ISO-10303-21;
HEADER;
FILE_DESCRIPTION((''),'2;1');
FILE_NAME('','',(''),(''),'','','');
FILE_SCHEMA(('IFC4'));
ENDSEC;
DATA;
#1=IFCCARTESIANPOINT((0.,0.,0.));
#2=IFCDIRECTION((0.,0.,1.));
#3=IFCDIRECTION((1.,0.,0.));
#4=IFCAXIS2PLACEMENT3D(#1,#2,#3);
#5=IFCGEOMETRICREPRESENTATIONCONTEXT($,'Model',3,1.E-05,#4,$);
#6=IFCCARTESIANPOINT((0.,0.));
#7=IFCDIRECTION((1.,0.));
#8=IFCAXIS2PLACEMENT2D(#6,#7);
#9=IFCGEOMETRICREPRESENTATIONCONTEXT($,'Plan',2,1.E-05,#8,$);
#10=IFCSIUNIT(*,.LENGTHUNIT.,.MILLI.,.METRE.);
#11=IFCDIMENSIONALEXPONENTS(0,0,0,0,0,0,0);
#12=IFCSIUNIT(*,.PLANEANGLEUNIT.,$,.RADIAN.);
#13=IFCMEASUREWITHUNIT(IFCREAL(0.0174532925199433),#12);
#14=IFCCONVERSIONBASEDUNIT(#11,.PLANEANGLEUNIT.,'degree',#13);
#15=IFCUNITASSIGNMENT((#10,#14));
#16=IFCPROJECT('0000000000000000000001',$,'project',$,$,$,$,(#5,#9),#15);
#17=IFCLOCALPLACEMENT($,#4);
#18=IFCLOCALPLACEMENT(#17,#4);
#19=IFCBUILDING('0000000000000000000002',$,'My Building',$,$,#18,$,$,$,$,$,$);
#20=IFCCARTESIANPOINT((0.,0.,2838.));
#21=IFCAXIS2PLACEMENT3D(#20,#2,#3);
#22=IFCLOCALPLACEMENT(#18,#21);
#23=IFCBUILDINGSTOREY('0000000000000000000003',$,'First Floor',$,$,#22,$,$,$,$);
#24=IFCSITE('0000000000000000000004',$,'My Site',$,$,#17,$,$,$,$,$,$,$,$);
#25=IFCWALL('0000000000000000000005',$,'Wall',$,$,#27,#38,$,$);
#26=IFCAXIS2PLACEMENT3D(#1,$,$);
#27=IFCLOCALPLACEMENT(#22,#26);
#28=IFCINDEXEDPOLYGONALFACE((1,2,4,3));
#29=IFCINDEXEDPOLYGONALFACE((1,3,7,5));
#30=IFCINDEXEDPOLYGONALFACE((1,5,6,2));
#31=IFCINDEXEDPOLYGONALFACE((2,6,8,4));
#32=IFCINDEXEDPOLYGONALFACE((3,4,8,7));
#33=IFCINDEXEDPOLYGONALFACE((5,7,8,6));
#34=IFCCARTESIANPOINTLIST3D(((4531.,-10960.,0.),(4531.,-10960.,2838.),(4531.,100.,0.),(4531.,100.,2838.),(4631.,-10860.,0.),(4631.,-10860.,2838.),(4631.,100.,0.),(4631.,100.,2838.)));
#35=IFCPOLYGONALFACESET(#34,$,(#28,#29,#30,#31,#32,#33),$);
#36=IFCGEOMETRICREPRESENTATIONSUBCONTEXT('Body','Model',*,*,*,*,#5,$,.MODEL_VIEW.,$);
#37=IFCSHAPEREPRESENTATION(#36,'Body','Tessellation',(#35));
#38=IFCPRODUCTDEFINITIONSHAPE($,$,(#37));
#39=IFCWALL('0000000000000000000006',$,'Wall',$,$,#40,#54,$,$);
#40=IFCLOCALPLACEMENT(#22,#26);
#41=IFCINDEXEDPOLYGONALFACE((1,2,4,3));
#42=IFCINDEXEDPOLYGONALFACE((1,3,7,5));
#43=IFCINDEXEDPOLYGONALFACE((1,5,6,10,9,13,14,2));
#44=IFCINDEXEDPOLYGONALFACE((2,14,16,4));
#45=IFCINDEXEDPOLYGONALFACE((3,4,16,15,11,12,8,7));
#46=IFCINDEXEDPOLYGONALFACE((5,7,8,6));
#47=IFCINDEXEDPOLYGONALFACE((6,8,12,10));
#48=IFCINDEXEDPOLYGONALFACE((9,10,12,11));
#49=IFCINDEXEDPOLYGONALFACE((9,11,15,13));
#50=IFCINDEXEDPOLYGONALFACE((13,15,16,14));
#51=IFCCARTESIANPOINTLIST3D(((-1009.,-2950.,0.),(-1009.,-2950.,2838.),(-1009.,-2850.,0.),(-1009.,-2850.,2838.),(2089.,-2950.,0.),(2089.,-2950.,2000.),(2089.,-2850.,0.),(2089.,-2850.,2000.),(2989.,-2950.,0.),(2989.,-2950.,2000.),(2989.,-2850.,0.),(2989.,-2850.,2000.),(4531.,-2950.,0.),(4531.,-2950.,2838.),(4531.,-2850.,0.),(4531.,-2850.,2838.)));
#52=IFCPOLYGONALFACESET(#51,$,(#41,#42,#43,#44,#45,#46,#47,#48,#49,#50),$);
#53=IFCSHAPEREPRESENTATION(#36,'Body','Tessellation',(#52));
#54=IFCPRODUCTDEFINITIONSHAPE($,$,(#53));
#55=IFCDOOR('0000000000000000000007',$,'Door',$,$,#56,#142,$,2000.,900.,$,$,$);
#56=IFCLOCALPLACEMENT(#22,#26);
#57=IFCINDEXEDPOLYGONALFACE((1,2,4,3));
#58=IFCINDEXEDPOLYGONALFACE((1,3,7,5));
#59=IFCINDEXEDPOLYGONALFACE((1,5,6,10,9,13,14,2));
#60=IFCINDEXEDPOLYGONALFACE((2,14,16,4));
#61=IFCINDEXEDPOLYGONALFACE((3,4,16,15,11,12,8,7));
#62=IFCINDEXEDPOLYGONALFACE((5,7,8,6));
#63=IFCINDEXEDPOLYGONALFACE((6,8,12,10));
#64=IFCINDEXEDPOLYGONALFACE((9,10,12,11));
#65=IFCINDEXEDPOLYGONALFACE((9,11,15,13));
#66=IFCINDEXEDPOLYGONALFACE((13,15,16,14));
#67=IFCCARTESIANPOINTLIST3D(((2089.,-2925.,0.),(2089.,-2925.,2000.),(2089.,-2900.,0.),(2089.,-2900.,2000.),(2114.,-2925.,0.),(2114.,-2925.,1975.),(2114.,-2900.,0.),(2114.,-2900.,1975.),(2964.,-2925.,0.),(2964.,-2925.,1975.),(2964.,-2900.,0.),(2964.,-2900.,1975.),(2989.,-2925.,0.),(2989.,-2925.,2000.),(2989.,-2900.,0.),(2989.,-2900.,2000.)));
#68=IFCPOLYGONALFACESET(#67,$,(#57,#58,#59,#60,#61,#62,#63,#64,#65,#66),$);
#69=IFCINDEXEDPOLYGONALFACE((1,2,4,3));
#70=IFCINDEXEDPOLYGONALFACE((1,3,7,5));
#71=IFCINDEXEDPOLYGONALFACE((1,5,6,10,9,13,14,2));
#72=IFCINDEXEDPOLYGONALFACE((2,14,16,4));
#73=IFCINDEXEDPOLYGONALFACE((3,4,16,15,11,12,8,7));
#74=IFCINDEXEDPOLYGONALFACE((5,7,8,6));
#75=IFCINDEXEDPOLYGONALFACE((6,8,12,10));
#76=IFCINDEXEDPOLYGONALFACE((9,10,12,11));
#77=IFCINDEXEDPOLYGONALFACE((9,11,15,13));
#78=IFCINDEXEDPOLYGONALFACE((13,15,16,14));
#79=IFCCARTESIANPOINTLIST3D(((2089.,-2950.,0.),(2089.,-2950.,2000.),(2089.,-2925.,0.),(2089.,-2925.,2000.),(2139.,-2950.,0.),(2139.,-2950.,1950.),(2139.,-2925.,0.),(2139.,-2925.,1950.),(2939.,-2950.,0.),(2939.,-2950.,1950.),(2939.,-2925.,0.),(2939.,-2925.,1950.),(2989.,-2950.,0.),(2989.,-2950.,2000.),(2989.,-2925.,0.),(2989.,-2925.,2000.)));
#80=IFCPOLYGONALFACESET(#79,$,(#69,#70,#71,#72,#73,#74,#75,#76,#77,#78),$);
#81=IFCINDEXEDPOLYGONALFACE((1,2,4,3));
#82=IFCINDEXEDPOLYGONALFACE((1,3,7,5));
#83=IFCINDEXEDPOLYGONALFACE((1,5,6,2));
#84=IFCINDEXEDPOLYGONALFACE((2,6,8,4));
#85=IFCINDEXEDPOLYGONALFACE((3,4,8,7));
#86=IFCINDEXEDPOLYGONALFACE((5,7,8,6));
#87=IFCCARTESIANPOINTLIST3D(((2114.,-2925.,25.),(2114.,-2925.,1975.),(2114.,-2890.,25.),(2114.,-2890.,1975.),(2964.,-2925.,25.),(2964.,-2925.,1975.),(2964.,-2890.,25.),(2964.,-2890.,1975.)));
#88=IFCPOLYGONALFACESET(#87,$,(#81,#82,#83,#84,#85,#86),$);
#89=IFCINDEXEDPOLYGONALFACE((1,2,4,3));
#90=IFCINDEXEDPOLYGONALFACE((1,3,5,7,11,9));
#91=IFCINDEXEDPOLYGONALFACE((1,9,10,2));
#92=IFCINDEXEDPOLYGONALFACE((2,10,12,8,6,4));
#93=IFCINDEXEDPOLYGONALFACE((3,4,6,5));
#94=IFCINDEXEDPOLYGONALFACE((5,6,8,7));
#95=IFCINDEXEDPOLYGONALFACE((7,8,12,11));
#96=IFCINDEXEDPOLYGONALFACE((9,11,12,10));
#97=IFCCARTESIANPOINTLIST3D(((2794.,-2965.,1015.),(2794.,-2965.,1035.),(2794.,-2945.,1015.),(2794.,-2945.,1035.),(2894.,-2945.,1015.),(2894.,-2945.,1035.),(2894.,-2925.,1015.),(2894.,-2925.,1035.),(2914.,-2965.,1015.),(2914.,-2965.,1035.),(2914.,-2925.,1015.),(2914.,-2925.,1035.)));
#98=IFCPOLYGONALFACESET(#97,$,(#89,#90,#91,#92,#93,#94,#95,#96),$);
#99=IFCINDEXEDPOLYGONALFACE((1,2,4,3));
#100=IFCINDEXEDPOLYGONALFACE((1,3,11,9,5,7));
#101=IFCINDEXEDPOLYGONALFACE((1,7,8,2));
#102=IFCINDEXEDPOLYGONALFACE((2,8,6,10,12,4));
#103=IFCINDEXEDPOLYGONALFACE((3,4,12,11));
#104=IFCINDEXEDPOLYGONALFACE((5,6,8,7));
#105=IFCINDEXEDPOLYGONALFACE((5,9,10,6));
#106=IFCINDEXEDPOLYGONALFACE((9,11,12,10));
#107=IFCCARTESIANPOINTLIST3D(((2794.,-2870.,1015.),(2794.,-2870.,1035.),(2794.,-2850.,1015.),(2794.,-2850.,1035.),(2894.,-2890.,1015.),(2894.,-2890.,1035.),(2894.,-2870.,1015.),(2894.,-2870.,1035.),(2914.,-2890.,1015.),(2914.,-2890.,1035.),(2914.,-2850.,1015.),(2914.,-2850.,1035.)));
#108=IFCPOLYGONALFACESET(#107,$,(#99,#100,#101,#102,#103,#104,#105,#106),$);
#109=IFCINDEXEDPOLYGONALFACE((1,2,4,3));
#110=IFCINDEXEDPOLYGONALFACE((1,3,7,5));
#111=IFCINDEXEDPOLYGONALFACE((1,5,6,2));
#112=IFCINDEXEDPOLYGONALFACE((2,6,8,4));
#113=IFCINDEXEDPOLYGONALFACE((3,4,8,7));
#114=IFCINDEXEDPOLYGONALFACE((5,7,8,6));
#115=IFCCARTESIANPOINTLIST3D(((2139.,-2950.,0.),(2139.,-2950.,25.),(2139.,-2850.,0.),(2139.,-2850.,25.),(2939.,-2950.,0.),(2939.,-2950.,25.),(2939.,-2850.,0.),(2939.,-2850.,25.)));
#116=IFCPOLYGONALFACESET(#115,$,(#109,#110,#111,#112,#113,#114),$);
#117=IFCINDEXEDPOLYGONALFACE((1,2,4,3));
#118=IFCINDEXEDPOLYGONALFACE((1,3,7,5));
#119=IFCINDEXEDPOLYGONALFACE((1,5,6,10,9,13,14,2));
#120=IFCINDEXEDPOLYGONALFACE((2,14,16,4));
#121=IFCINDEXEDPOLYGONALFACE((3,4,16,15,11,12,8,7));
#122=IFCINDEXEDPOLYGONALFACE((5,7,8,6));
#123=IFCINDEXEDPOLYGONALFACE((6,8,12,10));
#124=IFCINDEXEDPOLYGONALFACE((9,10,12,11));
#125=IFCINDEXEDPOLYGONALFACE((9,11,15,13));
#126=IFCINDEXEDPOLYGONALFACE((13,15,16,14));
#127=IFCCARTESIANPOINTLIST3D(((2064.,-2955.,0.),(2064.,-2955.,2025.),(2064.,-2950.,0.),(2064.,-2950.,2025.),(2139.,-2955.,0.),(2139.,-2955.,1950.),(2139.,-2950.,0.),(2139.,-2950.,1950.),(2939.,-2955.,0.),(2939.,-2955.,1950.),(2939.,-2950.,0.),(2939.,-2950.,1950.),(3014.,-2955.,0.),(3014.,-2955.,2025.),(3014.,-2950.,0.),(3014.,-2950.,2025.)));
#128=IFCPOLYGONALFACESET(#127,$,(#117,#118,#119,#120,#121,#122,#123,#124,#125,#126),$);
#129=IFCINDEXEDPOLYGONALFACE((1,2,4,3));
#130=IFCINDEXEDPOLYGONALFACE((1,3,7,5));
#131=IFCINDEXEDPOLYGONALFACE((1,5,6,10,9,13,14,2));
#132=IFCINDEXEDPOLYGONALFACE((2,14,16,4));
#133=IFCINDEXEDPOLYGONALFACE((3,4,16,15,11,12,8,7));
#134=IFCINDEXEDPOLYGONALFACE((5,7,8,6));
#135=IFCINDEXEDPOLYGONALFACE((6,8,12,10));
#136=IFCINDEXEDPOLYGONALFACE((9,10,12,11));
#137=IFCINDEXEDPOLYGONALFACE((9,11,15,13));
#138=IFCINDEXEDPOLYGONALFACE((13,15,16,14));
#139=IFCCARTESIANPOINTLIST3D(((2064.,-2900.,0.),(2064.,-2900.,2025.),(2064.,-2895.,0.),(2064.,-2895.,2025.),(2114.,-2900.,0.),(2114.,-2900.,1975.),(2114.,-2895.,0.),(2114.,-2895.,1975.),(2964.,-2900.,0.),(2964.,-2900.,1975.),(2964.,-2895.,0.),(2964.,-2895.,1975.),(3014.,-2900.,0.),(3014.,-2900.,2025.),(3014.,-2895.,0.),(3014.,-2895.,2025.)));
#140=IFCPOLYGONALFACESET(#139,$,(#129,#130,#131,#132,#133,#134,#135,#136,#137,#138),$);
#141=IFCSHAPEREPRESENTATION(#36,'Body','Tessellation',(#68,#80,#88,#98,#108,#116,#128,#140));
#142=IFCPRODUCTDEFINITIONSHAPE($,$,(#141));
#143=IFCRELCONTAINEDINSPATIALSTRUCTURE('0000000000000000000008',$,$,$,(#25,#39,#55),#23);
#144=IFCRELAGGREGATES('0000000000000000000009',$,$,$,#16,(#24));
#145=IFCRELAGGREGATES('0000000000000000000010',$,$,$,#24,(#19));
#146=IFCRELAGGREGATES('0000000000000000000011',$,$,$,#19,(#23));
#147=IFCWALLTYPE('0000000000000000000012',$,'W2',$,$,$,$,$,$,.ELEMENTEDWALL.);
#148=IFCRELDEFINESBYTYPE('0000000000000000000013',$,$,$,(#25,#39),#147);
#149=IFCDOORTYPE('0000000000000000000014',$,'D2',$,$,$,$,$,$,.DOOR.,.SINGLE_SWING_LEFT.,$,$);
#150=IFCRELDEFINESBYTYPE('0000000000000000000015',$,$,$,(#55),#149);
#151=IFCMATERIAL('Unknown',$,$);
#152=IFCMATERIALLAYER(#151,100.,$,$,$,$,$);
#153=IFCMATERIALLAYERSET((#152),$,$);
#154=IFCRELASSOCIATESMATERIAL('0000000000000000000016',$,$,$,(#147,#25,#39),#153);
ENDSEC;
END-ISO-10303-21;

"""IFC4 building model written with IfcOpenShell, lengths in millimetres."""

from ifc_helpers import new_model, entity, si_unit, converted_unit, frame, origin_with_axes, origin_2d_with_axis, place, context, subcontext, project, spatial, line, indexed_curve, outline, extrude, clip, halfspace, shape, source, transform, mapped, material, layer, layer_set, layer_usage, type_object, type_shapes, element, fill, save


model = new_model("IFC4")

# Units and contexts
model_context = context("Model", 3, precision=1e-05, world=origin_with_axes())
plan_context = context("Plan", 2, precision=1e-05, world=origin_2d_with_axis())
body_context_1 = subcontext(model_context, "Body", "Model", "MODEL_VIEW")
body_context_2 = subcontext(plan_context, "Body", "Plan", "PLAN_VIEW")
ifc_project = project(units=[si_unit("LENGTHUNIT", "METRE", prefix="MILLI"), converted_unit("PLANEANGLEUNIT", "degree", entity("IfcReal", 0.0174532925199433), si_unit("PLANEANGLEUNIT", "RADIAN"), dimensions=[0, 0, 0, 0, 0, 0, 0])], contexts=[model_context, plan_context])

# Site, building, storey
site_placement = place(None, origin_with_axes())
site = spatial("IfcSite", under=ifc_project, at=site_placement, Name="My Site")
building_placement = place(site_placement, origin_with_axes())
building = spatial("IfcBuilding", under=site, at=building_placement, Name="My Building")
storey_placement = place(building_placement, frame((0.0, 0.0, 2838.0), z_axis=(0.0, 0.0, 1.0), x_axis=(1.0, 0.0, 0.0)))
storey = spatial("IfcBuildingStorey", under=building, at=storey_placement, Name="First Floor")

# Shared definitions
ifc_material = material(Name="Unknown")

# Shared definitions
ifc_layer_1 = layer(ifc_material, 100.0)
ifc_layer_set_1 = layer_set([ifc_layer_1])
wall_type = type_object("IfcWallType", Name="W2", PredefinedType="ELEMENTEDWALL", material=ifc_layer_set_1)

# Wall
ifc_layer_usage_1 = layer_usage(ifc_layer_set_1, "AXIS2", "POSITIVE", 0.0)
wall_1_placement = place(storey_placement, frame((4531.0, 100.0, 0.0), z_axis=(0.0, 0.0, 1.0), x_axis=(0.0, -1.0, 0.0)))
element("IfcWall", 1, at=wall_1_placement, inside=storey, type_object=wall_type, material=ifc_layer_usage_1, Name="Wall", context=body_context_1, shape_type="Clipping", body=[
    clip(extrude(outline(indexed_curve([(0.0, 0.0), (0.0, 100.0), (11060.0, 100.0), (11060.0, 0.0), (0.0, 0.0)], self_intersect=False)), origin_with_axes(), (0.0, 0.0, 1.0), 2838.0), halfspace(frame((11060.0, 0.0, -2838.0), z_axis=(0.707105, 0.707109, 0.0), x_axis=(0.707109, -0.707105, 0.0)), False)),
])

# Wall, opening, door
ifc_layer_usage_2 = layer_usage(ifc_layer_set_1, "AXIS2", "POSITIVE", 0.0)
wall_2_placement = place(storey_placement, frame((-1009.0, -2950.0, 0.0), z_axis=(0.0, 0.0, 1.0), x_axis=(1.0, 0.0, 0.0)))
wall_2 = element("IfcWall", 2, at=wall_2_placement, inside=storey, type_object=wall_type, material=ifc_layer_usage_2, Name="Wall", context=body_context_1, shape_type="SweptSolid", body=[
    extrude(outline(indexed_curve([(0.0, 0.0), (0.0, 100.0), (5540.0, 100.0), (5540.0, 0.0), (0.0, 0.0)], self_intersect=False)), origin_with_axes(), (0.0, 0.0, 1.0), 2838.0),
])
shared_shape_1 = source(origin_with_axes(), body_context_1, "Body", "SolidModel", [
    extrude(outline(indexed_curve([(0.0, 0.0), (900.0, 0.0), (900.0, 2000.0), (0.0, 2000.0)], segments=[line(1, 2, 3, 4, 1)])), frame((0.0, -600.0, 0.0), z_axis=(0.0, -1.0, 0.0), x_axis=(1.0, 0.0, 0.0)), (0.0, 0.0, -1.0), 1200.0),
])
opening_1_placement = place(wall_2_placement, frame((3098.0, 0.0, 0.0), z_axis=(0.0, 0.0, 1.0), x_axis=(1.0, 0.0, 0.0)))
opening_1 = element("IfcOpeningElement", 3, at=opening_1_placement, cuts=wall_2, PredefinedType="OPENING", context=body_context_1, shape_type="MappedRepresentation", body=[
    mapped(shared_shape_1, transform((0.0, 0.0, 0.0), x_axis=(1.0, 0.0, 0.0), y_axis=(0.0, 1.0, 0.0), z_axis=(0.0, 0.0, 1.0), scale=1.0)),
])
door_type_1 = type_object("IfcDoorType", Name="D2", OperationType="SINGLE_SWING_LEFT", PredefinedType="DOOR")
shared_shape_2 = source(origin_with_axes(), body_context_1, "Body", "SolidModel", [
    extrude(outline(indexed_curve([(0.0, 0.0), (0.0, 2000.0), (900.0, 2000.0), (900.0, 0.0), (875.0, 0.0), (875.0, 1975.0), (25.0, 1975.0), (25.0, 0.0)], segments=[line(1, 2, 3, 4, 5, 6, 7, 8, 1)])), frame((0.0, 25.0, 0.0), z_axis=(0.0, -1.0, 0.0), x_axis=(1.0, 0.0, 0.0)), (0.0, 0.0, -1.0), 25.0),
    extrude(outline(indexed_curve([(0.0, 0.0), (0.0, 2000.0), (900.0, 2000.0), (900.0, 0.0), (850.0, 0.0), (850.0, 1950.0), (50.0, 1950.0), (50.0, 0.0)], segments=[line(1, 2, 3, 4, 5, 6, 7, 8, 1)])), frame((0.0, 0.0, 0.0), z_axis=(0.0, -1.0, 0.0), x_axis=(1.0, 0.0, 0.0)), (0.0, 0.0, -1.0), 25.0),
    extrude(outline(indexed_curve([(0.0, 0.0), (850.0, 0.0), (850.0, 35.0), (0.0, 35.0)], segments=[line(1, 2, 3, 4, 1)])), frame((25.0, 25.0, 25.0), z_axis=(0.0, 0.0, 1.0), x_axis=(1.0, 0.0, 0.0)), (0.0, 0.0, 1.0), 1950.0),
    extrude(outline(indexed_curve([(0.0, 0.0), (0.0, -40.0), (-120.0, -40.0), (-120.0, -20.0), (-20.0, -20.0), (-20.0, 0.0)], segments=[line(1, 2, 3, 4, 5, 6, 1)])), frame((825.0, 25.0, 1015.0), z_axis=(0.0, 0.0, 1.0), x_axis=(1.0, 0.0, 0.0)), (0.0, 0.0, 1.0), 20.0),
    extrude(outline(indexed_curve([(0.0, 0.0), (0.0, 40.0), (-120.0, 40.0), (-120.0, 20.0), (-20.0, 20.0), (-20.0, 0.0)], segments=[line(1, 2, 3, 4, 5, 6, 1)])), frame((825.0, 60.0, 1015.0), z_axis=(0.0, 0.0, 1.0), x_axis=(1.0, 0.0, 0.0)), (0.0, 0.0, 1.0), 20.0),
    extrude(outline(indexed_curve([(0.0, 0.0), (800.0, 0.0), (800.0, 100.0), (0.0, 100.0)], segments=[line(1, 2, 3, 4, 1)])), frame((50.0, 0.0, 0.0), z_axis=(0.0, 0.0, 1.0), x_axis=(1.0, 0.0, 0.0)), (0.0, 0.0, 1.0), 25.0),
    extrude(outline(indexed_curve([(0.0, 0.0), (0.0, 2025.0), (950.0, 2025.0), (950.0, 0.0), (875.0, 0.0), (875.0, 1950.0), (75.0, 1950.0), (75.0, 0.0)], segments=[line(1, 2, 3, 4, 5, 6, 7, 8, 1)])), frame((-25.0, -5.0, 0.0), z_axis=(0.0, -1.0, 0.0), x_axis=(1.0, 0.0, 0.0)), (0.0, 0.0, -1.0), 5.0),
    extrude(outline(indexed_curve([(0.0, 0.0), (0.0, 2025.0), (950.0, 2025.0), (950.0, 0.0), (900.0, 0.0), (900.0, 1975.0), (50.0, 1975.0), (50.0, 0.0)], segments=[line(1, 2, 3, 4, 5, 6, 7, 8, 1)])), frame((-25.0, 50.0, 0.0), z_axis=(0.0, -1.0, 0.0), x_axis=(1.0, 0.0, 0.0)), (0.0, 0.0, -1.0), 5.0),
])
shared_shape_3 = source(origin_with_axes(), body_context_2, "Body", "Curve2D", [
    entity("IfcIndexedPolyCurve", entity("IfcCartesianPointList2D", [[0.0, 0.0], [0.0, 50.0], [25.0, 50.0], [25.0, 25.0], [50.0, 25.0], [50.0, 0.0]]), [entity("IfcLineIndex", [1, 2, 3, 4, 5, 6, 1])]),
    entity("IfcIndexedPolyCurve", entity("IfcCartesianPointList2D", [[900.0, 0.0], [900.0, 50.0], [875.0, 50.0], [875.0, 25.0], [850.0, 25.0], [850.0, 0.0]]), [entity("IfcLineIndex", [1, 2, 3, 4, 5, 6, 1])]),
    entity("IfcTrimmedCurve", entity("IfcEllipse", entity("IfcAxis2Placement2D", entity("IfcCartesianPoint", [60.0, 50.0]), entity("IfcDirection", [1.0, 0.0])), 815.0, 850.0), [entity("IfcCartesianPoint", [875.0, 50.0])], [entity("IfcCartesianPoint", [60.0, 900.0])], True, "CARTESIAN"),
    entity("IfcIndexedPolyCurve", entity("IfcCartesianPointList2D", [[25.0, 50.0], [60.0, 50.0], [60.0, 900.0], [25.0, 900.0]]), [entity("IfcLineIndex", [1, 2, 3, 4, 1])]),
])
type_shapes(door_type_1, [shared_shape_2, shared_shape_3])
door_1_placement = place(opening_1_placement, origin_with_axes())
door_1 = element("IfcDoor", 4, at=door_1_placement, inside=storey, type_object=door_type_1, Name="Door", OverallHeight=2000.0, OverallWidth=900.0, shapes=[
    shape(body_context_1, "Body", "MappedRepresentation", [mapped(shared_shape_2, transform((0.0, 0.0, 0.0), x_axis=(1.0, 0.0, 0.0), y_axis=(0.0, 1.0, 0.0), z_axis=(0.0, 0.0, 1.0), scale=1.0))]),
    shape(body_context_2, "Body", "MappedRepresentation", [mapped(shared_shape_3, transform((0.0, 0.0, 0.0), x_axis=(1.0, 0.0, 0.0), y_axis=(0.0, 1.0, 0.0), z_axis=(0.0, 0.0, 1.0), scale=1.0))]),
])
fill(opening_1, door_1)

save(model, "model.ifc")
